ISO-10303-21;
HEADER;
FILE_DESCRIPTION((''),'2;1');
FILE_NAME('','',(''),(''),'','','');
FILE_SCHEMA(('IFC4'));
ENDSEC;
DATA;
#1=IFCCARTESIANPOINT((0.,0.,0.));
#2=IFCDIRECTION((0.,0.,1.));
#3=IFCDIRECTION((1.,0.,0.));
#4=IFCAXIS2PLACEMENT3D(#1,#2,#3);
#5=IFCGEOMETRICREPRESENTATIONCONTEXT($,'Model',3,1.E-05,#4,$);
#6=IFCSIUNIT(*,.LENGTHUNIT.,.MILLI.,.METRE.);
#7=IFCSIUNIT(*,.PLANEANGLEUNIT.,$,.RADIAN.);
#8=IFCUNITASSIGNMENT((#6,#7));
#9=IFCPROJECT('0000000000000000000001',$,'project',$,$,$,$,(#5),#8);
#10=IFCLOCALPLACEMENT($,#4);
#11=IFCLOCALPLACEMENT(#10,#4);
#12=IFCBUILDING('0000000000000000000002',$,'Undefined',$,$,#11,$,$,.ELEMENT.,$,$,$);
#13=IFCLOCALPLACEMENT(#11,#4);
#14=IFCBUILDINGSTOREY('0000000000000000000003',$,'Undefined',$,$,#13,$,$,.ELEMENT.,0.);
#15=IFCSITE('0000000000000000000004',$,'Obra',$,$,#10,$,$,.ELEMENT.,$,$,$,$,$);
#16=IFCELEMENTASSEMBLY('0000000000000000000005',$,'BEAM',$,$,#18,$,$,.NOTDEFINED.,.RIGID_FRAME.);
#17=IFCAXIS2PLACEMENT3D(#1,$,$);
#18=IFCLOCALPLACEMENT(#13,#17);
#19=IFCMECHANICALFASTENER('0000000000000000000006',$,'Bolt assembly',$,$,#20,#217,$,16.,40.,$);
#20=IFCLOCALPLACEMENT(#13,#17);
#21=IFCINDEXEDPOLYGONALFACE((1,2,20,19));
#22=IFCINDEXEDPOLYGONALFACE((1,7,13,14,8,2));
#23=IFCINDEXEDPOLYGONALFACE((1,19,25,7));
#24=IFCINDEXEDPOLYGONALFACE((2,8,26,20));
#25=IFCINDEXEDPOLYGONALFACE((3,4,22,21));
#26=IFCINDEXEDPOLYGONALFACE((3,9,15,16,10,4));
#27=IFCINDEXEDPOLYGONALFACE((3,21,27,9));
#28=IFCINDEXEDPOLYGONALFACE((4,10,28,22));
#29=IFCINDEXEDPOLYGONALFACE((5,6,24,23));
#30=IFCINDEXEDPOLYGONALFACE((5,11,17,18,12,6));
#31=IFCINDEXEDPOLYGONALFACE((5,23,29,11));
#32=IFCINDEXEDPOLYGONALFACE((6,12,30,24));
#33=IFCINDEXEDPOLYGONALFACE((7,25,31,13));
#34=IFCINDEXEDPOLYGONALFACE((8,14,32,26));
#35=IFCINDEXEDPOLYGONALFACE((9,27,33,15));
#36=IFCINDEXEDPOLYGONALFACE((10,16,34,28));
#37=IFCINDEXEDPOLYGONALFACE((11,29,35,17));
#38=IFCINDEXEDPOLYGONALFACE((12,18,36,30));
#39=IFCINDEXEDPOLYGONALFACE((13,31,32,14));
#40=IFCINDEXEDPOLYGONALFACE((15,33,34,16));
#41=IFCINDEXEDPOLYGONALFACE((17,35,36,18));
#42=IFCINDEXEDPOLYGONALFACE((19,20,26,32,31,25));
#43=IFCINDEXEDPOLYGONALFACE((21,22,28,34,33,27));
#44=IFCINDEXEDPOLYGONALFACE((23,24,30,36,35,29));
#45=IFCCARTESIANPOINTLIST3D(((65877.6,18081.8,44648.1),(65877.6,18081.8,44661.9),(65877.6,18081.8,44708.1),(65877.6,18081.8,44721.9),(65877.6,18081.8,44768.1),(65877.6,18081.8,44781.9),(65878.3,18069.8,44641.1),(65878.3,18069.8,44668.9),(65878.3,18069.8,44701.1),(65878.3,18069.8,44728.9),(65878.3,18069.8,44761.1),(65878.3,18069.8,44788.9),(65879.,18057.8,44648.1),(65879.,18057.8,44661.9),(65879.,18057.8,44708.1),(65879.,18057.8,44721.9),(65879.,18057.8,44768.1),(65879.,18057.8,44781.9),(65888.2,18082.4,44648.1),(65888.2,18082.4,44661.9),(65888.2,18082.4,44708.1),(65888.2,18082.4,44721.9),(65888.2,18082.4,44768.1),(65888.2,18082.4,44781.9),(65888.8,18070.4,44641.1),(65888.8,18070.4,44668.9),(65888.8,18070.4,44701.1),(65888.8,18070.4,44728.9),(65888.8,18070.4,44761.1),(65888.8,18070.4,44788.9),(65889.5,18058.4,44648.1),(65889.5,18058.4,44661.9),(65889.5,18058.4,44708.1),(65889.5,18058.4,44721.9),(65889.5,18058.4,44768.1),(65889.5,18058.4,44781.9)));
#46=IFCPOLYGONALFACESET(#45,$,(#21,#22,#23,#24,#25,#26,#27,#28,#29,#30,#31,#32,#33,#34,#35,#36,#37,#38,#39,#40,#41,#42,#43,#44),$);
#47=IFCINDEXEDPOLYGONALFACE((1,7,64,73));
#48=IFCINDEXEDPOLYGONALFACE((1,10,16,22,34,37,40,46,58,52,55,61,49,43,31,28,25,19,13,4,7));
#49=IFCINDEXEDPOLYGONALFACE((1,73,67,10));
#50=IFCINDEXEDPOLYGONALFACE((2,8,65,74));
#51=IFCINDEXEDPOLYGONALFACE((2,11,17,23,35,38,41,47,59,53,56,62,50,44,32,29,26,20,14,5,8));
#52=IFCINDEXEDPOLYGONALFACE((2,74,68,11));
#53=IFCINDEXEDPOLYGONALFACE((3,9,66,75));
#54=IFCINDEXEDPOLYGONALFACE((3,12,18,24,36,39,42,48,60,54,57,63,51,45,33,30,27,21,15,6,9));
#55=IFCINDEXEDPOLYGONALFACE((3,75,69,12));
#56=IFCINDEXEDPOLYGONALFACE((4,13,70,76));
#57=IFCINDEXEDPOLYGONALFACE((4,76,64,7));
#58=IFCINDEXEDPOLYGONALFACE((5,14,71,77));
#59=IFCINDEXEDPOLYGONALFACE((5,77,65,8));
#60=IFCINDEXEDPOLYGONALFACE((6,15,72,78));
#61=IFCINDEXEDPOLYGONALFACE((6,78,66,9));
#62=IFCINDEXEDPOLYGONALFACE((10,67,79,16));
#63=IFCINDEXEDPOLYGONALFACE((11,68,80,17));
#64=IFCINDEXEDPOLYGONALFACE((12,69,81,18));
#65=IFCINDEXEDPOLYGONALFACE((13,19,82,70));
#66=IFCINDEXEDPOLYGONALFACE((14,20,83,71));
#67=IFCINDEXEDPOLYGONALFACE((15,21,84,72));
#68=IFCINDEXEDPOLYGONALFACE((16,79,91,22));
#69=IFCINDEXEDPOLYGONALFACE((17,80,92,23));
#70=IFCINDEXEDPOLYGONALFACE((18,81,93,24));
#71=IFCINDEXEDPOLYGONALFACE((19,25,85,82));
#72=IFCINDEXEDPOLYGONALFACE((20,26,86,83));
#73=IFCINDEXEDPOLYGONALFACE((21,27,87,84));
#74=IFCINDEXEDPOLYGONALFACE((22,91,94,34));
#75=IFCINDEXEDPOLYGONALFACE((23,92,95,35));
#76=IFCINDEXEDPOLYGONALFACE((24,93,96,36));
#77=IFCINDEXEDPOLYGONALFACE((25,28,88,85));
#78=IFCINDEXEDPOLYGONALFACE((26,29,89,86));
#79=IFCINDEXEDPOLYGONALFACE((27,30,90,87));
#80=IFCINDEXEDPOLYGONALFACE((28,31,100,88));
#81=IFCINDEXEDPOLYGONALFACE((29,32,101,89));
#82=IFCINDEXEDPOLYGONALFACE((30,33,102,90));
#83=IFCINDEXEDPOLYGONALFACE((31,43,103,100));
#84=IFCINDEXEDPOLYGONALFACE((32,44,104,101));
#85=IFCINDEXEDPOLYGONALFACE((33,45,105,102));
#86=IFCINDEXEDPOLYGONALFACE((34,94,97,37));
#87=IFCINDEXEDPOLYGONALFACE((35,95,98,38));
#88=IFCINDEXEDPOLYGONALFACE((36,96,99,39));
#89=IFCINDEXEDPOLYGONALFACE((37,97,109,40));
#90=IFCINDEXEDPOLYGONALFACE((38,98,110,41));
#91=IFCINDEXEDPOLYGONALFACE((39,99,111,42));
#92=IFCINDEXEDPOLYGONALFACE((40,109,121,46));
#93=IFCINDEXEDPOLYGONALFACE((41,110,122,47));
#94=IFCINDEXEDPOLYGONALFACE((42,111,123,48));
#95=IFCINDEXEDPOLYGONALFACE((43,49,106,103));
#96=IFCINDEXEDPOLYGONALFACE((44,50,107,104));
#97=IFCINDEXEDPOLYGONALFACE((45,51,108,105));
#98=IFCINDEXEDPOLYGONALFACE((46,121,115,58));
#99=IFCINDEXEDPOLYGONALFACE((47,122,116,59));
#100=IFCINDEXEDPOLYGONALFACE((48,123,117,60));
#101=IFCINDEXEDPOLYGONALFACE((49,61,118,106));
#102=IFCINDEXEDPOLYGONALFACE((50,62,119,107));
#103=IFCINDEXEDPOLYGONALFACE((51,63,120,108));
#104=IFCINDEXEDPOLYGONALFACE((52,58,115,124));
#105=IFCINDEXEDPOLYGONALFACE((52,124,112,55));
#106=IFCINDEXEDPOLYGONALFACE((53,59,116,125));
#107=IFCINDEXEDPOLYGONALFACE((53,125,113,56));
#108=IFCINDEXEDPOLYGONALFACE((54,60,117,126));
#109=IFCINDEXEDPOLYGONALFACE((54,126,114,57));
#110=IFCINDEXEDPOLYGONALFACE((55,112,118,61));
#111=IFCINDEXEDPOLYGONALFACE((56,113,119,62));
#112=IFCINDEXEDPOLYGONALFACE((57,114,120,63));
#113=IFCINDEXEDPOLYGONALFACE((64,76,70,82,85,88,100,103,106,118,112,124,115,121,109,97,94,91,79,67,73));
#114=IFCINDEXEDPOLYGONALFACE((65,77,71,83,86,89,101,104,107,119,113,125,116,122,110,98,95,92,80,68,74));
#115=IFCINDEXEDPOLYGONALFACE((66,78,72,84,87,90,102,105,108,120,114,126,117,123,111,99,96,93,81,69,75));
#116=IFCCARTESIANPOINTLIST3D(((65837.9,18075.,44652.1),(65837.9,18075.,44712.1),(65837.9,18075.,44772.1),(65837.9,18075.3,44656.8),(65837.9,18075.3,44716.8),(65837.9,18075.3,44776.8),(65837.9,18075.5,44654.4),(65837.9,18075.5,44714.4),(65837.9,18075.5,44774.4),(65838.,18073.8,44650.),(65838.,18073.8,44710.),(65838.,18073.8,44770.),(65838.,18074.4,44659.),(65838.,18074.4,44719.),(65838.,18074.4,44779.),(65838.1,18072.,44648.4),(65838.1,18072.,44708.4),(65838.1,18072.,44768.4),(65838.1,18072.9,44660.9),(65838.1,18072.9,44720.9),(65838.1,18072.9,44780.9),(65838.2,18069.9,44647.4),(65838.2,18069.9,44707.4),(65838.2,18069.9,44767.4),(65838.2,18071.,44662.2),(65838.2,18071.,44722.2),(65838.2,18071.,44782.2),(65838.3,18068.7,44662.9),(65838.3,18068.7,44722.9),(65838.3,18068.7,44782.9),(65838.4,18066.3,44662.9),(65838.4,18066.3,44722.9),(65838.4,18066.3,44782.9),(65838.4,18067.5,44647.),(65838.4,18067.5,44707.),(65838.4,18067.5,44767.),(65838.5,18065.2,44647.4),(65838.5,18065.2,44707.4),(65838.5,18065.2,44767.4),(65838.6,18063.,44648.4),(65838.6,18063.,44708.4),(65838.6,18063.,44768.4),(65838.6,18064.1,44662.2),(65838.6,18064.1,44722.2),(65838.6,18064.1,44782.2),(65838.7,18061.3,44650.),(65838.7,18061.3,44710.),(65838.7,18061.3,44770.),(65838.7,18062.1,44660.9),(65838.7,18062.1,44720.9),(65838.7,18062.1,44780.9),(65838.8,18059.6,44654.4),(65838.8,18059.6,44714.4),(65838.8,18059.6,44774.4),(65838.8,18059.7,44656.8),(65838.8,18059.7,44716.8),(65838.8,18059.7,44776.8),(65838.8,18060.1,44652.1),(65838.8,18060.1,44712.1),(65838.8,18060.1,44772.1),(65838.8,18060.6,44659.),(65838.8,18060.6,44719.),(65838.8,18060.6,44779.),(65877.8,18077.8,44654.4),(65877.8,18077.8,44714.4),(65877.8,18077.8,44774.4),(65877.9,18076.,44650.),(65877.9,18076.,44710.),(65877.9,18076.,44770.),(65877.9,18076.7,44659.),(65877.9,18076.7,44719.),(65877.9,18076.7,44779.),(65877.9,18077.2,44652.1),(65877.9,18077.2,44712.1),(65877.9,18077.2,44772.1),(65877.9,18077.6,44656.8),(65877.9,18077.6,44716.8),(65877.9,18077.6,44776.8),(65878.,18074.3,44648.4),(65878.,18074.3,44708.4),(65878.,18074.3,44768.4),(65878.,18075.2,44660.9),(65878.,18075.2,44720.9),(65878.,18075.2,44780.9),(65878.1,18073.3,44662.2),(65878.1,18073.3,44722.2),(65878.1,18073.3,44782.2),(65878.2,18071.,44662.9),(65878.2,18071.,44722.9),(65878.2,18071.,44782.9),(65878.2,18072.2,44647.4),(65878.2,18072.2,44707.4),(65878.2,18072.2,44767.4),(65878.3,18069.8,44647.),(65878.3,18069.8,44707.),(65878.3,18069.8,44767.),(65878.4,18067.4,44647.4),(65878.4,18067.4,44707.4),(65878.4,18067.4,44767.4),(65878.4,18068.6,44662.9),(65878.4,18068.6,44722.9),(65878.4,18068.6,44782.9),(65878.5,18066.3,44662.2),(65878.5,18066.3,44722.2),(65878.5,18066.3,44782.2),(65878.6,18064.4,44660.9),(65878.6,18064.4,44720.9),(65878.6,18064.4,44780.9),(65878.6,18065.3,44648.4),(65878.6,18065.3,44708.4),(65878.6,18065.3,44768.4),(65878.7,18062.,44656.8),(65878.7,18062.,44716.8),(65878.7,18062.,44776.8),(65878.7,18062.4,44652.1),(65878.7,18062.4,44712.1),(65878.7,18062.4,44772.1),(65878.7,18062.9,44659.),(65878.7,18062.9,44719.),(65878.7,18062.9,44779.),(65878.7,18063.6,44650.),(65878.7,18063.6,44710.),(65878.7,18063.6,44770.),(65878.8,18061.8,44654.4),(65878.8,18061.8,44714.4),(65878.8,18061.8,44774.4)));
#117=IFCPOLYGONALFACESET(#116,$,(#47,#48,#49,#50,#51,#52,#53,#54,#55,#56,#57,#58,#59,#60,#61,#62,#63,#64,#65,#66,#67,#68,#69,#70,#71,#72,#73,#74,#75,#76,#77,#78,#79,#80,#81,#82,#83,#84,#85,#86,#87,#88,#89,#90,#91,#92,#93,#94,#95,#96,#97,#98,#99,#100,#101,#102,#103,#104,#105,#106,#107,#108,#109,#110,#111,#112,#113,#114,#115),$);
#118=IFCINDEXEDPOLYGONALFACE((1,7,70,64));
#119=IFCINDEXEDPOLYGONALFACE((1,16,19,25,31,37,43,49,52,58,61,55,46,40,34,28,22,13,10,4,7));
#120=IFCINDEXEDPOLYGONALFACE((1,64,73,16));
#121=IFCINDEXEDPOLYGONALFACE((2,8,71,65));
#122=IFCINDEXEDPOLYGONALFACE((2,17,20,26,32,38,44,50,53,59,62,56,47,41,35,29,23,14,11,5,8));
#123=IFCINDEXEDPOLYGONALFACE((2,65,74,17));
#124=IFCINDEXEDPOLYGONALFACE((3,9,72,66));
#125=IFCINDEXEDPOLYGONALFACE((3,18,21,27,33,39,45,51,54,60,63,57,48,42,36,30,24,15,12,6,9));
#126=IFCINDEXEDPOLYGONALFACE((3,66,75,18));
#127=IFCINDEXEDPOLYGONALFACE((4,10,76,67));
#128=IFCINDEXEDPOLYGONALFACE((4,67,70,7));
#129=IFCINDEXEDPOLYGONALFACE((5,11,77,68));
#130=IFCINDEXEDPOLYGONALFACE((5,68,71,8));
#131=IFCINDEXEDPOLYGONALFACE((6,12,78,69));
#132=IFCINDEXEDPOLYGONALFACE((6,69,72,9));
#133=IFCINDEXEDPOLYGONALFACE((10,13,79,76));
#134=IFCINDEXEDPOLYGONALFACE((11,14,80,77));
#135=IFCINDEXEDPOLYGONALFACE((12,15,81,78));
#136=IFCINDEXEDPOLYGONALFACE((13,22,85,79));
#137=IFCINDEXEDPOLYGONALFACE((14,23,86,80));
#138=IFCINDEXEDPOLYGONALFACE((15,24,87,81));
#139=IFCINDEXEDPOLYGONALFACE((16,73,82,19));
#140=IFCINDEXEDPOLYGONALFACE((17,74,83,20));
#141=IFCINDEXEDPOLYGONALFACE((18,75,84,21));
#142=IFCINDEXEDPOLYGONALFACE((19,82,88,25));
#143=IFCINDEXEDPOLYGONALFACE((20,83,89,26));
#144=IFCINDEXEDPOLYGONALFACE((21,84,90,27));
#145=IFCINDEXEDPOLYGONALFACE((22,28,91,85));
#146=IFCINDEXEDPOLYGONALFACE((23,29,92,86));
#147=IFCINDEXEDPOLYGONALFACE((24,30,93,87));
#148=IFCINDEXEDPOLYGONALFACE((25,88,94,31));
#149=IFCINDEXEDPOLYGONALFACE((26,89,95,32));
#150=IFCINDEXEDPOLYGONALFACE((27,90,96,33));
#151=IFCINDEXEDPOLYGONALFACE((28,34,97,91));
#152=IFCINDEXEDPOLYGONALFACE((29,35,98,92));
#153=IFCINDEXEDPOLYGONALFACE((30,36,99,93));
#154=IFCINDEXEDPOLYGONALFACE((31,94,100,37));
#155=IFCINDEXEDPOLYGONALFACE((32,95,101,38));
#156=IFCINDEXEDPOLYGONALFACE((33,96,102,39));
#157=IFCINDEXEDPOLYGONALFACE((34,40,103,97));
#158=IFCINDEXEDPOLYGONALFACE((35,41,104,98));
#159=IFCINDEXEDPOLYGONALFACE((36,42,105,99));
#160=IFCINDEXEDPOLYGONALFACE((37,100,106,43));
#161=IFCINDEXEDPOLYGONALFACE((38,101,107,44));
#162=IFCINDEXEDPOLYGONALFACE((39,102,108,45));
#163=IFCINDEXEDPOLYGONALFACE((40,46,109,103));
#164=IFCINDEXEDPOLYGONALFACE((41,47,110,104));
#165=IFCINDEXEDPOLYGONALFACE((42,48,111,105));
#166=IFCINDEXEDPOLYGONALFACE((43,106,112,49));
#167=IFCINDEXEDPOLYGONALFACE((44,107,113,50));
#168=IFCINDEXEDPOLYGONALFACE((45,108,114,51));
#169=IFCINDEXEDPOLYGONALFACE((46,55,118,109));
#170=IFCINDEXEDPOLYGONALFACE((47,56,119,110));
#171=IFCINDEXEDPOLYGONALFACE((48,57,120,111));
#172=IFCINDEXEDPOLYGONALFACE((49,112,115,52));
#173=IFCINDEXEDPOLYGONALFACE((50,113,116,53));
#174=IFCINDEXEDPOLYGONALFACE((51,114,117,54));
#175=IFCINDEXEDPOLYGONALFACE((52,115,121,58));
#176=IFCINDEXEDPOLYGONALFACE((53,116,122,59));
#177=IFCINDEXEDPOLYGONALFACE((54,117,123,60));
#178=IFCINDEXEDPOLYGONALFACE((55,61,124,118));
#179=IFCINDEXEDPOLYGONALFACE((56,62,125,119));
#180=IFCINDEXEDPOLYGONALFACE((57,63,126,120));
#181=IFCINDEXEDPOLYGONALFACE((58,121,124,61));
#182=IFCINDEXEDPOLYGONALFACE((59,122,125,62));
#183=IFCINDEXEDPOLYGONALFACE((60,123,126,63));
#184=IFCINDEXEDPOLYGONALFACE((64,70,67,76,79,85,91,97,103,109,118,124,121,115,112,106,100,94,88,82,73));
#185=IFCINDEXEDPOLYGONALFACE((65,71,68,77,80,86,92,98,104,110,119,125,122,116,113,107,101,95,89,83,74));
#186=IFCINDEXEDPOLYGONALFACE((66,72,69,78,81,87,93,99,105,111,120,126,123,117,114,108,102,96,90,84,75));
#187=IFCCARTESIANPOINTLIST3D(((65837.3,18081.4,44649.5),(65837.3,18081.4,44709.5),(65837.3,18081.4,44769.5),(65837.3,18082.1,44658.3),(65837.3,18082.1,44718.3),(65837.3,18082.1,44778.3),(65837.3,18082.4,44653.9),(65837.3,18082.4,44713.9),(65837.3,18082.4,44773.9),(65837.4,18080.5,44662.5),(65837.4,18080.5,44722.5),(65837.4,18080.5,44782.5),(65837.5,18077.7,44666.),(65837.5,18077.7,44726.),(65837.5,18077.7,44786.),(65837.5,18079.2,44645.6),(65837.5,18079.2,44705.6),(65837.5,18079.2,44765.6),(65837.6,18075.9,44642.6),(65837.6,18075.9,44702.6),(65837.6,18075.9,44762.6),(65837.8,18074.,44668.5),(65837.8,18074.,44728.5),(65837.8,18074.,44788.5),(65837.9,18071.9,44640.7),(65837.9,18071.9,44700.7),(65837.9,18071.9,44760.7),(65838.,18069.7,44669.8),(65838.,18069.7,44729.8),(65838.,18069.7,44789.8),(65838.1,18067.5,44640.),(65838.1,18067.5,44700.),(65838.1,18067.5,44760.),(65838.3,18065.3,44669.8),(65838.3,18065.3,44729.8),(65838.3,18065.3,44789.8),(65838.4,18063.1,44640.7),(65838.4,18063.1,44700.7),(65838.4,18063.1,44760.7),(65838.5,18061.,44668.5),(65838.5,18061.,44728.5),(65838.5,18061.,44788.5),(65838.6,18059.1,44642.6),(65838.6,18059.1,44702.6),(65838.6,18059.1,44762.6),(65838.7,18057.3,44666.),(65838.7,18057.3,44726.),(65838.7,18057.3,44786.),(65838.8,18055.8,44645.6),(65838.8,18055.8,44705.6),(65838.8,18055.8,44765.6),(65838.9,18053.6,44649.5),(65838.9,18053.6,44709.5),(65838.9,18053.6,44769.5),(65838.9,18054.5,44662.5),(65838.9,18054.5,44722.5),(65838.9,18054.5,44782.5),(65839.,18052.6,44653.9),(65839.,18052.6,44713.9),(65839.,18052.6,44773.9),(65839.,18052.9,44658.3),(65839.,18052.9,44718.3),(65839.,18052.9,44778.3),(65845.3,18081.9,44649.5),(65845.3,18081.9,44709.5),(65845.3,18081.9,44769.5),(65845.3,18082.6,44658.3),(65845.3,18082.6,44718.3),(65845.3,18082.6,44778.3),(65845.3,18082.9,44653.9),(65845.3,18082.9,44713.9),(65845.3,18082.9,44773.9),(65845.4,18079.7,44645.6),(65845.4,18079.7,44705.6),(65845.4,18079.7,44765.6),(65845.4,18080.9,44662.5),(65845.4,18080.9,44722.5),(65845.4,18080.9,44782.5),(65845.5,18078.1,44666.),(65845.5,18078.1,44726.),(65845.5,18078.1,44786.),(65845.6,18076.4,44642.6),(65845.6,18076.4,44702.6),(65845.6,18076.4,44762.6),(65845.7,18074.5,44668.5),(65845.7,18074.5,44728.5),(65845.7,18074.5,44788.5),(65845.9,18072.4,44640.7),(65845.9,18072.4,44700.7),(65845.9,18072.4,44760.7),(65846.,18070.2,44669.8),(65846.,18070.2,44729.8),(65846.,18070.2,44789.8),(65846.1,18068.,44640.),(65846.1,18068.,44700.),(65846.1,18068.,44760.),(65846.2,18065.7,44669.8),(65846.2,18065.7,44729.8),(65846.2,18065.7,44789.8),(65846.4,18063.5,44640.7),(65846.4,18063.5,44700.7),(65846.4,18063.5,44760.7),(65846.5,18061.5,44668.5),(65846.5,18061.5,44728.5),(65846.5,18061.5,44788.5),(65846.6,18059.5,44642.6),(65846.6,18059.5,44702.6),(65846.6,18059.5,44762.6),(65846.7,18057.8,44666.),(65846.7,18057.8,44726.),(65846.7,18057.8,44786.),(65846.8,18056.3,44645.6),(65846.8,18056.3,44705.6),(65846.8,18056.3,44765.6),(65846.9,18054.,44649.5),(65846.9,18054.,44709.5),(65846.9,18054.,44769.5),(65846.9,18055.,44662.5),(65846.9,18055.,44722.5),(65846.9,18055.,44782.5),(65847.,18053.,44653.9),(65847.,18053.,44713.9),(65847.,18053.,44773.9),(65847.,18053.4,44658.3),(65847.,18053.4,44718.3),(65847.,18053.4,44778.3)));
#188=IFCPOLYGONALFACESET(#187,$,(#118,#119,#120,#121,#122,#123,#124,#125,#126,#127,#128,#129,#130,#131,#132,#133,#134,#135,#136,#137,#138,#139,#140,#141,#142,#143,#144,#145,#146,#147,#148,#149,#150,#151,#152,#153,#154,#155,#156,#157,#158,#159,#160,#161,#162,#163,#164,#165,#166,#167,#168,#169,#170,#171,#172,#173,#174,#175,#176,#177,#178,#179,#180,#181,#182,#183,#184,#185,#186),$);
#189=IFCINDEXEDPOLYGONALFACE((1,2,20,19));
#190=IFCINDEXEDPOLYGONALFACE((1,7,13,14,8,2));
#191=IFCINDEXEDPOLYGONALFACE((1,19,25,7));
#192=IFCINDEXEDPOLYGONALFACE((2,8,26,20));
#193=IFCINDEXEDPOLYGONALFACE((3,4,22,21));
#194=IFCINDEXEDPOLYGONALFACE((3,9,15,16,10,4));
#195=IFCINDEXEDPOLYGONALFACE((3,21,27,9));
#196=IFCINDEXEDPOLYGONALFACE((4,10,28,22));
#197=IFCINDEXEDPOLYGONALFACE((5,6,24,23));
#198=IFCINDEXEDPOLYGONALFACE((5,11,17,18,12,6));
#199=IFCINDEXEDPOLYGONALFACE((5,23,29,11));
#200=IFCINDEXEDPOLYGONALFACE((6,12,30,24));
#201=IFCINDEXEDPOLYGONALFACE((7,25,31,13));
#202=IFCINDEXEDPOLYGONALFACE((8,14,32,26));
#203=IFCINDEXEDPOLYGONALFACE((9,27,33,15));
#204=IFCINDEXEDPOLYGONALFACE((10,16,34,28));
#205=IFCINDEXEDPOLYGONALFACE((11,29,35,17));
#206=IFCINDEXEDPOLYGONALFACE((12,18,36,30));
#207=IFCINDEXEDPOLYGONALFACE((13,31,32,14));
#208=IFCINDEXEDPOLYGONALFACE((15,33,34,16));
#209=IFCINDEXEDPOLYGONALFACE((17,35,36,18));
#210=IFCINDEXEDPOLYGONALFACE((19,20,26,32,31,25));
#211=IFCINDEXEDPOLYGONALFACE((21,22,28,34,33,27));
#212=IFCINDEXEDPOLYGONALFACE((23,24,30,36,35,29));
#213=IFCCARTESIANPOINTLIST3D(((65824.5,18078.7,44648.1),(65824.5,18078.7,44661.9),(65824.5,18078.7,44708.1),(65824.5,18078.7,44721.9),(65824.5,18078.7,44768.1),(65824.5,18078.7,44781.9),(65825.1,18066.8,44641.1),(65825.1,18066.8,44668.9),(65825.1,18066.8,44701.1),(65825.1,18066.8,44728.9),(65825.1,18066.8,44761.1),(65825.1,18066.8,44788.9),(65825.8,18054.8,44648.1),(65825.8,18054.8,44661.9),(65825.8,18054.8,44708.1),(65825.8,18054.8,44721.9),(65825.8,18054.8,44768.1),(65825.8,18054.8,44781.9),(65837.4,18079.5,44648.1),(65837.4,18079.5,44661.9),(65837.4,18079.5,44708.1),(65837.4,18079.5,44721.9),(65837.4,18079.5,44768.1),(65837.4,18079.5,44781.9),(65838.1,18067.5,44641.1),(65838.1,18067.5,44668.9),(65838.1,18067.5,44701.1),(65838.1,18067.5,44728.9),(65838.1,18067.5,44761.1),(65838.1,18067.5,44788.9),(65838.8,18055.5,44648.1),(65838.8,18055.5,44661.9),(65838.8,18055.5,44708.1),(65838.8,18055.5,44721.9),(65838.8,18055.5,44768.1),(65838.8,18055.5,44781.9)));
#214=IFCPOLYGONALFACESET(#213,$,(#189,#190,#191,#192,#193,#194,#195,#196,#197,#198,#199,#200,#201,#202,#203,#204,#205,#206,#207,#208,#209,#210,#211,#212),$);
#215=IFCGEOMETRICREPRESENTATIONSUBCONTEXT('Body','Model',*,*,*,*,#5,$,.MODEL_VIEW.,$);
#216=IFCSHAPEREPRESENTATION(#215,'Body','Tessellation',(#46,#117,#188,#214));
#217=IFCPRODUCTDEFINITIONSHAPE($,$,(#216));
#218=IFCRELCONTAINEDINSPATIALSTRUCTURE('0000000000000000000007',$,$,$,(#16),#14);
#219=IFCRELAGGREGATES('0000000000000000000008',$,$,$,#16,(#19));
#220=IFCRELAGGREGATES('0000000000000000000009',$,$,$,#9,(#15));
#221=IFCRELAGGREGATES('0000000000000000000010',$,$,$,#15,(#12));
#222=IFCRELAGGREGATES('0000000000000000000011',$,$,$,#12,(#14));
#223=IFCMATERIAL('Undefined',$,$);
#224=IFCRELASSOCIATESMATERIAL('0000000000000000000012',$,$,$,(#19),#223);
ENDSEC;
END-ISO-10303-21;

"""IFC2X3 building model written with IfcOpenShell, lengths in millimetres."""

from ifc_helpers import new_model, si_unit, frame, origin_with_axes, origin_2d_with_axis, place, context, subcontext, project, spatial, polyline, circle, outline, extrude, source, transform, mapped, material, element, aggregate, save


model = new_model("IFC2X3")

# Units and contexts
model_context = context("Model", 3, precision=1e-05, world=origin_with_axes())
body_context = subcontext(model_context, "Body", "Model", "MODEL_VIEW")
ifc_project = project(units=[si_unit("LENGTHUNIT", "METRE", prefix="MILLI"), si_unit("PLANEANGLEUNIT", "RADIAN")], contexts=[model_context])

# Site, building, storey
site_placement = place(None, origin_with_axes())
site = spatial("IfcSite", under=ifc_project, at=site_placement, Name="Obra", CompositionType="ELEMENT")
building_placement = place(site_placement, origin_with_axes())
building = spatial("IfcBuilding", under=site, at=building_placement, Name="Undefined", CompositionType="ELEMENT")
storey_placement = place(building_placement, origin_with_axes())
storey = spatial("IfcBuildingStorey", under=building, at=storey_placement, Name="Undefined", CompositionType="ELEMENT", Elevation=0.0)

# Element assembly
assembly_1_placement = place(storey_placement, origin_with_axes())
assembly_1 = element("IfcElementAssembly", 1, at=assembly_1_placement, inside=storey, Name="BEAM", AssemblyPlace="NOTDEFINED", PredefinedType="RIGID_FRAME")

# Mechanical fastener
ifc_material_1 = material(Name="Undefined")
shared_shape_1 = source(origin_with_axes(), body_context, "Body", "SweptSolid", [
    extrude(outline(polyline([(13.9, 0.0), (6.9, 12.0), (-6.9, 12.0), (-13.9, 0.0), (-6.9, -12.0), (6.9, -12.0), (13.9, 0.0)])), frame((0.0, -45.9, 0.0), z_axis=(0.0, 1.0, 0.0), x_axis=(1.0, 0.0, 0.0)), (0.0, 0.0, 1.0), 10.6),
    extrude(circle(Radius=8.0, at=origin_2d_with_axis()), frame((0.0, -35.3, 0.0), z_axis=(0.0, 1.0, 0.0), x_axis=(1.0, 0.0, 0.0)), (0.0, 0.0, 1.0), 40.0),
    extrude(circle(Radius=15.0, at=origin_2d_with_axis()), frame((0.0, -3.1, 0.0), z_axis=(0.0, 1.0, 0.0), x_axis=(1.0, 0.0, 0.0)), (0.0, 0.0, 1.0), 8.0),
    extrude(outline(polyline([(13.9, 0.0), (6.9, 12.0), (-6.9, 12.0), (-13.9, 0.0), (-6.9, -12.0), (6.9, -12.0), (13.9, 0.0)])), frame((0.0, 4.9, 0.0), z_axis=(0.0, 1.0, 0.0), x_axis=(1.0, 0.0, 0.0)), (0.0, 0.0, 1.0), 13.0),
])
mechanical_fastener_1_placement = place(assembly_1_placement, frame((65845.9, 18017.9, 44835.0), z_axis=(-0.057107, 0.998368, 0.0), x_axis=(0.0, 0.0, -1.0)))
mechanical_fastener_1 = element("IfcMechanicalFastener", 2, at=mechanical_fastener_1_placement, material=ifc_material_1, Name="Bolt assembly", NominalDiameter=16.0, NominalLength=40.0, context=body_context, shape_type="MappedRepresentation", body=[
    mapped(shared_shape_1, transform((60.0, 0.0, 50.0))),
    mapped(shared_shape_1, transform((120.0, 0.0, 50.0))),
    mapped(shared_shape_1, transform((180.0, 0.0, 50.0))),
])
aggregate(assembly_1, [mechanical_fastener_1])

save(model, "model.ifc")
